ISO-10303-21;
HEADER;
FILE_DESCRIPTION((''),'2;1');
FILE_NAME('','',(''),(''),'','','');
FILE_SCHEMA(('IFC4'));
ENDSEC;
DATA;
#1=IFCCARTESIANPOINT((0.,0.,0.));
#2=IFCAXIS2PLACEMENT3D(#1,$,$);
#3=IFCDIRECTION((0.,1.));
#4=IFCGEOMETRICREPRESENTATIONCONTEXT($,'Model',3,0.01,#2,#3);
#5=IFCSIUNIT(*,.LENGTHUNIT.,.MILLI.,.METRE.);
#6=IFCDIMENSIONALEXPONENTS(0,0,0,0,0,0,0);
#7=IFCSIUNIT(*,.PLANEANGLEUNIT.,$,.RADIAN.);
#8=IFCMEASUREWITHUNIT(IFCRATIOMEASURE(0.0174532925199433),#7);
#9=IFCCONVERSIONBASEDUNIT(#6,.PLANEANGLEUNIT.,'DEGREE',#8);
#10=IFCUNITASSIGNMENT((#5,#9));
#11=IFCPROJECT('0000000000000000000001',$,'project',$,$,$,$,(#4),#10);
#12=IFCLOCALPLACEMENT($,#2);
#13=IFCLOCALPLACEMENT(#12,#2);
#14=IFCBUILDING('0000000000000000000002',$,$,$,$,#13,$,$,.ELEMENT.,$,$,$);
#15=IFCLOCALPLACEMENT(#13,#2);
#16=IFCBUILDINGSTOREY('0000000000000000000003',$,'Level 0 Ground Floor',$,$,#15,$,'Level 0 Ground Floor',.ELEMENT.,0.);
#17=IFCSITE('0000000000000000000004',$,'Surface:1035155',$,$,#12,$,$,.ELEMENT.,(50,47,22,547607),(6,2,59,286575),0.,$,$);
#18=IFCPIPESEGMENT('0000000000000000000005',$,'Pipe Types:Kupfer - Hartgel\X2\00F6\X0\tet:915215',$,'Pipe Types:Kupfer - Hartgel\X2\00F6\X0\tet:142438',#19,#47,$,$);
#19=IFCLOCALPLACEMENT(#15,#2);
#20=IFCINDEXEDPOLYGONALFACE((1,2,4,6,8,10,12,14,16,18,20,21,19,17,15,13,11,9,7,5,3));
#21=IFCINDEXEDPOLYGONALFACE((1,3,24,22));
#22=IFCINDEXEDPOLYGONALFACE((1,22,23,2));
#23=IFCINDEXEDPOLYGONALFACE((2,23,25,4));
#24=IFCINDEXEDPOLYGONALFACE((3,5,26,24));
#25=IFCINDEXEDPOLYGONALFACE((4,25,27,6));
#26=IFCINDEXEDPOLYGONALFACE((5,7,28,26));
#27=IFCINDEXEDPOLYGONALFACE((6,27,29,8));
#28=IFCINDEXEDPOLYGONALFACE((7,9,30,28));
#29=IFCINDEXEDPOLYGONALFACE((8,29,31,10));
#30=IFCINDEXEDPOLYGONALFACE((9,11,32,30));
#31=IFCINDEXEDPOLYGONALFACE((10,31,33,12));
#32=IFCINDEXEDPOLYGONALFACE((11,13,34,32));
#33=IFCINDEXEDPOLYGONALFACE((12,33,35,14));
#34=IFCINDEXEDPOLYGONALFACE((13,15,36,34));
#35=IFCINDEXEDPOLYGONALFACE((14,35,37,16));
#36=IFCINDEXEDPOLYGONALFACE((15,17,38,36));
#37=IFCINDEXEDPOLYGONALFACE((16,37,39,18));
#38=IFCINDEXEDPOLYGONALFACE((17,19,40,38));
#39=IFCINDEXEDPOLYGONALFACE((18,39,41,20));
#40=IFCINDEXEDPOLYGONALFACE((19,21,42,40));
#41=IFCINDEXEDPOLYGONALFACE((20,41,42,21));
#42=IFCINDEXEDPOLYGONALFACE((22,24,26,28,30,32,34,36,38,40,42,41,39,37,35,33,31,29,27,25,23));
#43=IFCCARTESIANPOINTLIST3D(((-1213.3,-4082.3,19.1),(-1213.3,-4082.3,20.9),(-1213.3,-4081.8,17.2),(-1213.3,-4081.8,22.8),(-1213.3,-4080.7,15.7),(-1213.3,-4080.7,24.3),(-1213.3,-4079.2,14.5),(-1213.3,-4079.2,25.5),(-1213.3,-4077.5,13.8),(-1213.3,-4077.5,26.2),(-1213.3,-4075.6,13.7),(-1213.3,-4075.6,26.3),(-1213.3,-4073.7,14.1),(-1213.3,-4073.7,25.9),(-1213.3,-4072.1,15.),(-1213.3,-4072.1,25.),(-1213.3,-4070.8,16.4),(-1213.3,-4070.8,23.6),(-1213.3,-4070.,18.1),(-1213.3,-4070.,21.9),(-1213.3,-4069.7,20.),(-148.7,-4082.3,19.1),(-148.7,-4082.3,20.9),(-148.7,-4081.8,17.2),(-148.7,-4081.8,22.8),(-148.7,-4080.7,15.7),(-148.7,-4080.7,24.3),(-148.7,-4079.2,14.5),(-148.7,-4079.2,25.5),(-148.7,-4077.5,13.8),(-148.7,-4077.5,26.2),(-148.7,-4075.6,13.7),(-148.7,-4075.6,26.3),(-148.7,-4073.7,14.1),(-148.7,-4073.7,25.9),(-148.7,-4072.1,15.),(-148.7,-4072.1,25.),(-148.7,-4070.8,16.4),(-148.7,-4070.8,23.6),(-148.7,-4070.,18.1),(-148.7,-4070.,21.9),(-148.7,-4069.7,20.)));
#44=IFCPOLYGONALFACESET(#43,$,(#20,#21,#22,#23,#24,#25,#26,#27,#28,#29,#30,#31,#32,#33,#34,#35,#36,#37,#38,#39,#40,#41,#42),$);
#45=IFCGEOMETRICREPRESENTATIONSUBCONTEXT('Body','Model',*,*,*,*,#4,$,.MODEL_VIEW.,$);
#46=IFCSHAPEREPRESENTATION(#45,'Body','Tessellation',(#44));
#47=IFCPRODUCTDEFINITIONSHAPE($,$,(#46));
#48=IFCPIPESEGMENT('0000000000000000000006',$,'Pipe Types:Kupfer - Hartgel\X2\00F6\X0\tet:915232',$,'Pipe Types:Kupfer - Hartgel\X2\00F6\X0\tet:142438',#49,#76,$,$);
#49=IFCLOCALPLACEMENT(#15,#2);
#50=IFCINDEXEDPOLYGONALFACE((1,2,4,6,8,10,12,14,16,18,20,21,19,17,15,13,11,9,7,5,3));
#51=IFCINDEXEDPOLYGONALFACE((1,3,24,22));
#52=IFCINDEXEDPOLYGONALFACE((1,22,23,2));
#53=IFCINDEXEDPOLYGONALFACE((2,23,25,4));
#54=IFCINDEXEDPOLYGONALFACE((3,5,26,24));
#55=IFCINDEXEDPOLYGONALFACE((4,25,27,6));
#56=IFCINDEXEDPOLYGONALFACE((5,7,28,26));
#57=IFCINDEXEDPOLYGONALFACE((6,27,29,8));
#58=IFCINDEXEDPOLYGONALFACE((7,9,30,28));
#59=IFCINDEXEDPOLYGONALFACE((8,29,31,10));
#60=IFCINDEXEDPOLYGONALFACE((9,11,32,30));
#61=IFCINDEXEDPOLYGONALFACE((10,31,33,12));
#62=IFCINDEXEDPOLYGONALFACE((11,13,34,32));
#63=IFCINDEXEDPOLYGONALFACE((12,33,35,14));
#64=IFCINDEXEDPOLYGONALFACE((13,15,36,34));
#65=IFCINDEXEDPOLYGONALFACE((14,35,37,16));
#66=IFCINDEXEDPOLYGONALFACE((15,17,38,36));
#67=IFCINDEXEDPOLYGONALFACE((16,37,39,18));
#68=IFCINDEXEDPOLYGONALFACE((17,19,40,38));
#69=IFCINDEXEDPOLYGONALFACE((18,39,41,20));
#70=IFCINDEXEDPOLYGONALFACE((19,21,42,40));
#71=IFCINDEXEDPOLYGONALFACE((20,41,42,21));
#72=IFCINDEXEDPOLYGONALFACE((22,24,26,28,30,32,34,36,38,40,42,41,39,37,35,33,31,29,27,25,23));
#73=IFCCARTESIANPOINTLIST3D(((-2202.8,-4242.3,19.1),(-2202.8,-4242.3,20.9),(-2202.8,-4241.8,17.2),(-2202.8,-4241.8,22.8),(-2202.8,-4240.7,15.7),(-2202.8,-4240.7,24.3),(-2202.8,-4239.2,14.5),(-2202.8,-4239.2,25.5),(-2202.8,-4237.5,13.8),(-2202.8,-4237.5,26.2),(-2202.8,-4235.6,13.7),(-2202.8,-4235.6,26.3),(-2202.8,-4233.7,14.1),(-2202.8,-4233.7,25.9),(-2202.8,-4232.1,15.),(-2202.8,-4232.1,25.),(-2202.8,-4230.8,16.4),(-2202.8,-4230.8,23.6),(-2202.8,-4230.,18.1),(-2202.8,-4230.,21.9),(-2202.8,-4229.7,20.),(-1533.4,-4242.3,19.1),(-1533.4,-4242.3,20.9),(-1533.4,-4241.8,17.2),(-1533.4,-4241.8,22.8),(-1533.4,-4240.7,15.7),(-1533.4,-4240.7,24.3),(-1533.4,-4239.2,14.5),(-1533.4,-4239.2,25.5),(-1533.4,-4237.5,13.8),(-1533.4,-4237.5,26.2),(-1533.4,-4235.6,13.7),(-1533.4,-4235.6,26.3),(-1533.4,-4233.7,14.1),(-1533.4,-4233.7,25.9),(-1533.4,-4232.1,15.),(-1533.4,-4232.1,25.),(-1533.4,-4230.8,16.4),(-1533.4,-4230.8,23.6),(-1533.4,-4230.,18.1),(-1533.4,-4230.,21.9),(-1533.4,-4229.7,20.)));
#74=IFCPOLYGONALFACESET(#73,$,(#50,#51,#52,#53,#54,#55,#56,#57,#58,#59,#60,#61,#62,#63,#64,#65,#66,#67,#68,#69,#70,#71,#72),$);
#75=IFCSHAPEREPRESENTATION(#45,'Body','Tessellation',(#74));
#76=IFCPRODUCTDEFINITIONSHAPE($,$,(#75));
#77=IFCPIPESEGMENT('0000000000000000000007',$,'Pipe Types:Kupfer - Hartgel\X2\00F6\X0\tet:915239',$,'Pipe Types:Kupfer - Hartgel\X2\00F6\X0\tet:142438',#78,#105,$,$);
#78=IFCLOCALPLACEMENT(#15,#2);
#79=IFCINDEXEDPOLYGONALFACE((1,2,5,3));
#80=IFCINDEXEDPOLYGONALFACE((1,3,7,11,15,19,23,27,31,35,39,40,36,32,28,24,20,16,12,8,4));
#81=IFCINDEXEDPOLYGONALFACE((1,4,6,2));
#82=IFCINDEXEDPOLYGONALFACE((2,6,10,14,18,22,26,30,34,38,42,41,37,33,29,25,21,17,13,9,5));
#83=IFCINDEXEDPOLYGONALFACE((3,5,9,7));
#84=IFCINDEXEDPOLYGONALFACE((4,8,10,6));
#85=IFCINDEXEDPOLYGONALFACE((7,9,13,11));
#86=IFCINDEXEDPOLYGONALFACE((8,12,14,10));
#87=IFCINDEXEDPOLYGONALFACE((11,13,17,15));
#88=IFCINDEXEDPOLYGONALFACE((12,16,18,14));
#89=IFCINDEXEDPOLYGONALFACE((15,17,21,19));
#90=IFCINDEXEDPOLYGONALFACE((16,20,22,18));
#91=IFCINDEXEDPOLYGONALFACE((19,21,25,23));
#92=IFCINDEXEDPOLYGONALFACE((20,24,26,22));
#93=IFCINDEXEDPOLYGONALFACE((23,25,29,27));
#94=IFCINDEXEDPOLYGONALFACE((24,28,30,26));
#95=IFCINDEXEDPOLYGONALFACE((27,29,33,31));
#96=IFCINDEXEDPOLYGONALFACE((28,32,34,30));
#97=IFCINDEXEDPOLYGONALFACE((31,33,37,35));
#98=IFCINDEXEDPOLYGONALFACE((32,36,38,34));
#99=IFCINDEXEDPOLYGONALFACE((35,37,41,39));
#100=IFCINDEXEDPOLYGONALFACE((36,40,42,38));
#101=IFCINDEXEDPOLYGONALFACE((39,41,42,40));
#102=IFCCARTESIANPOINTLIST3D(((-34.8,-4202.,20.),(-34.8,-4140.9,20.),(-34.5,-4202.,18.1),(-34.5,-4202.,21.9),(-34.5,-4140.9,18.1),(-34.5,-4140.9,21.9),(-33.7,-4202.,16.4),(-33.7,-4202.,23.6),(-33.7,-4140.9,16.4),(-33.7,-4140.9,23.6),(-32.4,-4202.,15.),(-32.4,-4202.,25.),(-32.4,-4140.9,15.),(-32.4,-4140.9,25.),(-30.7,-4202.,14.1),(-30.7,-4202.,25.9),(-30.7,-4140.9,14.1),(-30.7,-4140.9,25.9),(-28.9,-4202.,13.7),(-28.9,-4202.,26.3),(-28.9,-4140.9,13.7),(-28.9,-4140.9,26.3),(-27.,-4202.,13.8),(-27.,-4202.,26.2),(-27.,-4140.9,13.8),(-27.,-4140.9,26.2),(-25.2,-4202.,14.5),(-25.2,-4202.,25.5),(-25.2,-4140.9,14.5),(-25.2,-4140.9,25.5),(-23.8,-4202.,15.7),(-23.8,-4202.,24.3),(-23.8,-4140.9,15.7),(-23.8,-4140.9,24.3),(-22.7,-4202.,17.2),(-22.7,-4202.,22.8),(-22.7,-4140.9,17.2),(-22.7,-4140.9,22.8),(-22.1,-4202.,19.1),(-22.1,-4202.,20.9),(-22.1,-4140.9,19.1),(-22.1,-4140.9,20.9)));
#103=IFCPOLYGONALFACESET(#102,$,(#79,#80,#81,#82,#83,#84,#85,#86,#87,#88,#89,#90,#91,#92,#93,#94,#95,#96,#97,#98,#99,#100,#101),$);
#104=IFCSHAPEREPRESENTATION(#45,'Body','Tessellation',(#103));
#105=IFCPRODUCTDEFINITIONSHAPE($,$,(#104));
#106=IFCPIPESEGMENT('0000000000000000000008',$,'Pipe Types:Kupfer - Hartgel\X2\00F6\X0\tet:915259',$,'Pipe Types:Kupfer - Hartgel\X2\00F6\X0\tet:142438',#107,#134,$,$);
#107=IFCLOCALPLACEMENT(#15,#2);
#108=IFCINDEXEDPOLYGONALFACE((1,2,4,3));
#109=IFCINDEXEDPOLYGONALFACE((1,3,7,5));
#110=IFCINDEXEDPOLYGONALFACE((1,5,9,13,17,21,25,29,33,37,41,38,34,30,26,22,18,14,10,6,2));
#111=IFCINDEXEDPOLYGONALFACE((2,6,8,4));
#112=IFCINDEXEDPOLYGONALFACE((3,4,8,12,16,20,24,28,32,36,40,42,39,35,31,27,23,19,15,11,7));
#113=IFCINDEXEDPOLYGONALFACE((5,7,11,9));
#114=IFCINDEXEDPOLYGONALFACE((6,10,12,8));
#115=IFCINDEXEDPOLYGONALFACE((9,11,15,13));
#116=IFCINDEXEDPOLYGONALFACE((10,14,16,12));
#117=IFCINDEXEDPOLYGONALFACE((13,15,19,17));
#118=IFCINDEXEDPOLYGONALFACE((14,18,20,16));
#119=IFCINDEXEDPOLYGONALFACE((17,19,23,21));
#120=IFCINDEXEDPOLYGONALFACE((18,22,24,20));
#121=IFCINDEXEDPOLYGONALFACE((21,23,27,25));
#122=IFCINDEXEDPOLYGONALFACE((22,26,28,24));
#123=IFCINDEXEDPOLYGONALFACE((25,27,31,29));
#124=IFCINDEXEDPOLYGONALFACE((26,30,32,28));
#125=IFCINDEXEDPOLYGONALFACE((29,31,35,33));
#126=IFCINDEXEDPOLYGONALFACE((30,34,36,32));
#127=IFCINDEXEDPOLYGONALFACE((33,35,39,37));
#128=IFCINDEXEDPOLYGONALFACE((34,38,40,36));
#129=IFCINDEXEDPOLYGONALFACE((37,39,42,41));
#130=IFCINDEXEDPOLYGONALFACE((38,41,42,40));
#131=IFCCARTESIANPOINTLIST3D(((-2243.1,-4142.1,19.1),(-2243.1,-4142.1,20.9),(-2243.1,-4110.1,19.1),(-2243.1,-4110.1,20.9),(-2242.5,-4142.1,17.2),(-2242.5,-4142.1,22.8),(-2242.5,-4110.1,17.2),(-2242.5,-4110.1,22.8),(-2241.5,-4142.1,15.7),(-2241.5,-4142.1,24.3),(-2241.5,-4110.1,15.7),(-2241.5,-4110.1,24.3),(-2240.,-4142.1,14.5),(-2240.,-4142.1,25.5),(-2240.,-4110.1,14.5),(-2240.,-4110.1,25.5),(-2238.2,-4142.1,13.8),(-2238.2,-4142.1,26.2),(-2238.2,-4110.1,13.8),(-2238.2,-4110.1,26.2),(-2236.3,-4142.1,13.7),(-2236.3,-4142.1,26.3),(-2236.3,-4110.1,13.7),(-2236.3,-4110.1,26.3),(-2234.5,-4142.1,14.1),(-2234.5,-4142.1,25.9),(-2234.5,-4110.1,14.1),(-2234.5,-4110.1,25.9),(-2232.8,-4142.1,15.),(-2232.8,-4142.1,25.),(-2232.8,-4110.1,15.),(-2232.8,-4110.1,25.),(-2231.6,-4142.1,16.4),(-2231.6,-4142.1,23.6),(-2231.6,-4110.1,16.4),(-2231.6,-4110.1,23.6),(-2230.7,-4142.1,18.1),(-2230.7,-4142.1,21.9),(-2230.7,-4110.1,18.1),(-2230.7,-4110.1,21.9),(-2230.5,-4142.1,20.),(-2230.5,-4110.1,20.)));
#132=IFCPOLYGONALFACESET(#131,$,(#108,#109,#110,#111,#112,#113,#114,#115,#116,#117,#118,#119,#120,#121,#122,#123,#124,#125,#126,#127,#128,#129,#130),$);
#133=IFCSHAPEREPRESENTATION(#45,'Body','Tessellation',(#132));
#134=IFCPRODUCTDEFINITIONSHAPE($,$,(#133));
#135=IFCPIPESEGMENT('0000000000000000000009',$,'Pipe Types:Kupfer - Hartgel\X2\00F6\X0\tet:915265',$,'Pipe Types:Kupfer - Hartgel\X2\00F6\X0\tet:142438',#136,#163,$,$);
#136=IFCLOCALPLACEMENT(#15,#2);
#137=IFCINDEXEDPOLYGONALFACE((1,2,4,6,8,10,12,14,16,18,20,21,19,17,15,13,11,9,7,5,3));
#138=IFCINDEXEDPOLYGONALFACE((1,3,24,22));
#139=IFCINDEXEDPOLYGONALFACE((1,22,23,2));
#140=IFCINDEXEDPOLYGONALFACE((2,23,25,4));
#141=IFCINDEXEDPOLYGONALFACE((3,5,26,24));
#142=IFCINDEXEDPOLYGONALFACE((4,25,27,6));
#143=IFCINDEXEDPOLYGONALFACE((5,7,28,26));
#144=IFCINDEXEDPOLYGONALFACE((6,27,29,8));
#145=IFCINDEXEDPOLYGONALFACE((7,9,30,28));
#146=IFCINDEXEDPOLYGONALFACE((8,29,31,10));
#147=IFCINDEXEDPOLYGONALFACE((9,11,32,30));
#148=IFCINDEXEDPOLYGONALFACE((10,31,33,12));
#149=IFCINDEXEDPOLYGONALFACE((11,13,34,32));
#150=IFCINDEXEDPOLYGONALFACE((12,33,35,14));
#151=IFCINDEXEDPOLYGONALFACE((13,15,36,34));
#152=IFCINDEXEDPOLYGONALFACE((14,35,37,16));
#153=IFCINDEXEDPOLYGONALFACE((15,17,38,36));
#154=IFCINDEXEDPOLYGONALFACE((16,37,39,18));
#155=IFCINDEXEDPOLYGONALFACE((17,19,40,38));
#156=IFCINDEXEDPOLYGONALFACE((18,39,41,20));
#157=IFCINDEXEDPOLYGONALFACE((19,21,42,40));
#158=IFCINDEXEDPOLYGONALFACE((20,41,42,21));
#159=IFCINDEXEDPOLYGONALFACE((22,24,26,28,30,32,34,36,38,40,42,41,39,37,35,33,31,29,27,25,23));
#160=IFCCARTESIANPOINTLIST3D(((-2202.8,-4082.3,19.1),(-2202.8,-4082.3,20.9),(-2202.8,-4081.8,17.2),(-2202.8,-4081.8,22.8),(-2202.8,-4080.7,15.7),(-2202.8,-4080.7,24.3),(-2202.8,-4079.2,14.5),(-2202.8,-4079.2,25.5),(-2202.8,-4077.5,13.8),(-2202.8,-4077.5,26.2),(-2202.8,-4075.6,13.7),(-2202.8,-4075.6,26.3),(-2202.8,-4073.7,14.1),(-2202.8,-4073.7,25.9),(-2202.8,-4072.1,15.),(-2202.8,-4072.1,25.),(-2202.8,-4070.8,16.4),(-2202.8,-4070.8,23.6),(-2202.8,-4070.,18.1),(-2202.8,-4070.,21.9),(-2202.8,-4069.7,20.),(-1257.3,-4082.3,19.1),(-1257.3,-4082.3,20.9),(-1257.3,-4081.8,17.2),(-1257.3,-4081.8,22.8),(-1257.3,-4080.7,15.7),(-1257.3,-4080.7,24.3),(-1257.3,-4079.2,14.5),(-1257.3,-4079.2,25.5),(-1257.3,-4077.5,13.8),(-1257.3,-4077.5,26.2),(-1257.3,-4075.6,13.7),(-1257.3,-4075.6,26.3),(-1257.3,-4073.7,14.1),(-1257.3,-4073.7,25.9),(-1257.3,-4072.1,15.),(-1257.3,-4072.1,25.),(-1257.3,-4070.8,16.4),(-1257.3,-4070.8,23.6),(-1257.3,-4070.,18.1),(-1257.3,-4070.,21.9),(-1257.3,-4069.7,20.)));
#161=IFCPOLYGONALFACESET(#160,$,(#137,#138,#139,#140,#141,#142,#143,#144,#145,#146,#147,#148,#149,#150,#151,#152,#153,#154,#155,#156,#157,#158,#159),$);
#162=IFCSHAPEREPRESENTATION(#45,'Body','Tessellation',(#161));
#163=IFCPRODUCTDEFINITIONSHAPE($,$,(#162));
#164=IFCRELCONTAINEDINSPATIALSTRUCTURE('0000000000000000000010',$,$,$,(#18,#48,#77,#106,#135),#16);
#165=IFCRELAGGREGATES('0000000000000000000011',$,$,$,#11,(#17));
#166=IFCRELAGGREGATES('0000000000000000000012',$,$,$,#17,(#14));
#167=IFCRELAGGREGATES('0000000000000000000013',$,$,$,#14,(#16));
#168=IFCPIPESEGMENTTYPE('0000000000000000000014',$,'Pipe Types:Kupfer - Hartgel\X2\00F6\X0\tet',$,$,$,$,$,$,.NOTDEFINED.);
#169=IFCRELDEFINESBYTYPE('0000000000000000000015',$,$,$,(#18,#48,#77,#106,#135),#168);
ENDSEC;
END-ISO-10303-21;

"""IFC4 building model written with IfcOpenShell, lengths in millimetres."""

from ifc_helpers import new_model, entity, si_unit, converted_unit, direction, frame, frame_2d, origin, place, context, subcontext, project, spatial, circle, extrude, type_object, element, save


model = new_model("IFC4")

# Units and contexts
model_context = context("Model", 3, precision=0.01, world=origin(), true_north=direction((0.0, 1.0)))
body_context = subcontext(model_context, "Body", "Model", "MODEL_VIEW")
ifc_project = project(units=[si_unit("LENGTHUNIT", "METRE", prefix="MILLI"), converted_unit("PLANEANGLEUNIT", "DEGREE", entity("IfcRatioMeasure", 0.0174532925199433), si_unit("PLANEANGLEUNIT", "RADIAN"), dimensions=[0, 0, 0, 0, 0, 0, 0])], contexts=[model_context])

# Site, building, storey
site_placement = place(None, origin())
site = spatial("IfcSite", under=ifc_project, at=site_placement, Name="Surface:1035155", CompositionType="ELEMENT", RefLatitude=(50, 47, 22, 547607), RefLongitude=(6, 2, 59, 286575), RefElevation=0.0)
building_placement = place(site_placement, origin())
building = spatial("IfcBuilding", under=site, at=building_placement, CompositionType="ELEMENT")
storey_placement = place(building_placement, origin())
storey = spatial("IfcBuildingStorey", under=building, at=storey_placement, Name="Level 0 Ground Floor", LongName="Level 0 Ground Floor", CompositionType="ELEMENT", Elevation=0.0)

# Pipe segments
pipe_segment_type = type_object("IfcPipeSegmentType", Name="Pipe Types:Kupfer - Hartgelötet", PredefinedType="NOTDEFINED")
pipe_segment_1_placement = place(storey_placement, frame((-1213.3, -4084.0, 12.1)))
element("IfcPipeSegment", 1, at=pipe_segment_1_placement, inside=storey, type_object=pipe_segment_type, Name="Pipe Types:Kupfer - Hartgelötet:915215", ObjectType="Pipe Types:Kupfer - Hartgelötet:142438", context=body_context, shape_type="SweptSolid", body=[
    extrude(circle(Radius=6.3, at=frame_2d((0.0, 0.0), x_axis=(1.0, 0.0))), frame((0.0, 7.9, 7.9), z_axis=(1.0, 0.0, 0.0), x_axis=(0.0, 1.0, 0.0)), (0.0, 0.0, 1.0), 1064.6),
])
pipe_segment_2_placement = place(storey_placement, frame((-2202.8, -4244.0, 12.1)))
element("IfcPipeSegment", 2, at=pipe_segment_2_placement, inside=storey, type_object=pipe_segment_type, Name="Pipe Types:Kupfer - Hartgelötet:915232", ObjectType="Pipe Types:Kupfer - Hartgelötet:142438", context=body_context, shape_type="SweptSolid", body=[
    extrude(circle(Radius=6.3, at=frame_2d((0.0, 0.0), x_axis=(1.0, 0.0))), frame((0.0, 7.9, 7.9), z_axis=(1.0, 0.000044, 0.0), x_axis=(-0.000044, 1.0, 0.0)), (0.0, 0.0, 1.0), 669.4),
])
pipe_segment_3_placement = place(storey_placement, frame((-36.4, -4202.0, 12.1)))
element("IfcPipeSegment", 3, at=pipe_segment_3_placement, inside=storey, type_object=pipe_segment_type, Name="Pipe Types:Kupfer - Hartgelötet:915239", ObjectType="Pipe Types:Kupfer - Hartgelötet:142438", context=body_context, shape_type="SweptSolid", body=[
    extrude(circle(Radius=6.3, at=frame_2d((0.0, 0.0), x_axis=(1.0, 0.0))), frame((7.9, 0.0, 7.9), z_axis=(0.0, 1.0, 0.0), x_axis=(-1.0, 0.0, 0.0)), (0.0, 0.0, 1.0), 61.1),
])
pipe_segment_4_placement = place(storey_placement, frame((-2244.8, -4142.1, 12.1)))
element("IfcPipeSegment", 4, at=pipe_segment_4_placement, inside=storey, type_object=pipe_segment_type, Name="Pipe Types:Kupfer - Hartgelötet:915259", ObjectType="Pipe Types:Kupfer - Hartgelötet:142438", context=body_context, shape_type="SweptSolid", body=[
    extrude(circle(Radius=6.3, at=frame_2d((0.0, 0.0), x_axis=(1.0, 0.0))), frame((7.9, 0.0, 7.9), z_axis=(0.0, 1.0, 0.0), x_axis=(1.0, 0.0, 0.0)), (0.0, 0.0, 1.0), 32.0),
])
pipe_segment_5_placement = place(storey_placement, frame((-2202.8, -4084.0, 12.1)))
element("IfcPipeSegment", 5, at=pipe_segment_5_placement, inside=storey, type_object=pipe_segment_type, Name="Pipe Types:Kupfer - Hartgelötet:915265", ObjectType="Pipe Types:Kupfer - Hartgelötet:142438", context=body_context, shape_type="SweptSolid", body=[
    extrude(circle(Radius=6.3, at=frame_2d((0.0, 0.0), x_axis=(1.0, 0.0))), frame((0.0, 7.9, 7.9), z_axis=(1.0, 0.0, 0.0), x_axis=(0.0, 1.0, 0.0)), (0.0, 0.0, 1.0), 945.5),
])

save(model, "model.ifc")
